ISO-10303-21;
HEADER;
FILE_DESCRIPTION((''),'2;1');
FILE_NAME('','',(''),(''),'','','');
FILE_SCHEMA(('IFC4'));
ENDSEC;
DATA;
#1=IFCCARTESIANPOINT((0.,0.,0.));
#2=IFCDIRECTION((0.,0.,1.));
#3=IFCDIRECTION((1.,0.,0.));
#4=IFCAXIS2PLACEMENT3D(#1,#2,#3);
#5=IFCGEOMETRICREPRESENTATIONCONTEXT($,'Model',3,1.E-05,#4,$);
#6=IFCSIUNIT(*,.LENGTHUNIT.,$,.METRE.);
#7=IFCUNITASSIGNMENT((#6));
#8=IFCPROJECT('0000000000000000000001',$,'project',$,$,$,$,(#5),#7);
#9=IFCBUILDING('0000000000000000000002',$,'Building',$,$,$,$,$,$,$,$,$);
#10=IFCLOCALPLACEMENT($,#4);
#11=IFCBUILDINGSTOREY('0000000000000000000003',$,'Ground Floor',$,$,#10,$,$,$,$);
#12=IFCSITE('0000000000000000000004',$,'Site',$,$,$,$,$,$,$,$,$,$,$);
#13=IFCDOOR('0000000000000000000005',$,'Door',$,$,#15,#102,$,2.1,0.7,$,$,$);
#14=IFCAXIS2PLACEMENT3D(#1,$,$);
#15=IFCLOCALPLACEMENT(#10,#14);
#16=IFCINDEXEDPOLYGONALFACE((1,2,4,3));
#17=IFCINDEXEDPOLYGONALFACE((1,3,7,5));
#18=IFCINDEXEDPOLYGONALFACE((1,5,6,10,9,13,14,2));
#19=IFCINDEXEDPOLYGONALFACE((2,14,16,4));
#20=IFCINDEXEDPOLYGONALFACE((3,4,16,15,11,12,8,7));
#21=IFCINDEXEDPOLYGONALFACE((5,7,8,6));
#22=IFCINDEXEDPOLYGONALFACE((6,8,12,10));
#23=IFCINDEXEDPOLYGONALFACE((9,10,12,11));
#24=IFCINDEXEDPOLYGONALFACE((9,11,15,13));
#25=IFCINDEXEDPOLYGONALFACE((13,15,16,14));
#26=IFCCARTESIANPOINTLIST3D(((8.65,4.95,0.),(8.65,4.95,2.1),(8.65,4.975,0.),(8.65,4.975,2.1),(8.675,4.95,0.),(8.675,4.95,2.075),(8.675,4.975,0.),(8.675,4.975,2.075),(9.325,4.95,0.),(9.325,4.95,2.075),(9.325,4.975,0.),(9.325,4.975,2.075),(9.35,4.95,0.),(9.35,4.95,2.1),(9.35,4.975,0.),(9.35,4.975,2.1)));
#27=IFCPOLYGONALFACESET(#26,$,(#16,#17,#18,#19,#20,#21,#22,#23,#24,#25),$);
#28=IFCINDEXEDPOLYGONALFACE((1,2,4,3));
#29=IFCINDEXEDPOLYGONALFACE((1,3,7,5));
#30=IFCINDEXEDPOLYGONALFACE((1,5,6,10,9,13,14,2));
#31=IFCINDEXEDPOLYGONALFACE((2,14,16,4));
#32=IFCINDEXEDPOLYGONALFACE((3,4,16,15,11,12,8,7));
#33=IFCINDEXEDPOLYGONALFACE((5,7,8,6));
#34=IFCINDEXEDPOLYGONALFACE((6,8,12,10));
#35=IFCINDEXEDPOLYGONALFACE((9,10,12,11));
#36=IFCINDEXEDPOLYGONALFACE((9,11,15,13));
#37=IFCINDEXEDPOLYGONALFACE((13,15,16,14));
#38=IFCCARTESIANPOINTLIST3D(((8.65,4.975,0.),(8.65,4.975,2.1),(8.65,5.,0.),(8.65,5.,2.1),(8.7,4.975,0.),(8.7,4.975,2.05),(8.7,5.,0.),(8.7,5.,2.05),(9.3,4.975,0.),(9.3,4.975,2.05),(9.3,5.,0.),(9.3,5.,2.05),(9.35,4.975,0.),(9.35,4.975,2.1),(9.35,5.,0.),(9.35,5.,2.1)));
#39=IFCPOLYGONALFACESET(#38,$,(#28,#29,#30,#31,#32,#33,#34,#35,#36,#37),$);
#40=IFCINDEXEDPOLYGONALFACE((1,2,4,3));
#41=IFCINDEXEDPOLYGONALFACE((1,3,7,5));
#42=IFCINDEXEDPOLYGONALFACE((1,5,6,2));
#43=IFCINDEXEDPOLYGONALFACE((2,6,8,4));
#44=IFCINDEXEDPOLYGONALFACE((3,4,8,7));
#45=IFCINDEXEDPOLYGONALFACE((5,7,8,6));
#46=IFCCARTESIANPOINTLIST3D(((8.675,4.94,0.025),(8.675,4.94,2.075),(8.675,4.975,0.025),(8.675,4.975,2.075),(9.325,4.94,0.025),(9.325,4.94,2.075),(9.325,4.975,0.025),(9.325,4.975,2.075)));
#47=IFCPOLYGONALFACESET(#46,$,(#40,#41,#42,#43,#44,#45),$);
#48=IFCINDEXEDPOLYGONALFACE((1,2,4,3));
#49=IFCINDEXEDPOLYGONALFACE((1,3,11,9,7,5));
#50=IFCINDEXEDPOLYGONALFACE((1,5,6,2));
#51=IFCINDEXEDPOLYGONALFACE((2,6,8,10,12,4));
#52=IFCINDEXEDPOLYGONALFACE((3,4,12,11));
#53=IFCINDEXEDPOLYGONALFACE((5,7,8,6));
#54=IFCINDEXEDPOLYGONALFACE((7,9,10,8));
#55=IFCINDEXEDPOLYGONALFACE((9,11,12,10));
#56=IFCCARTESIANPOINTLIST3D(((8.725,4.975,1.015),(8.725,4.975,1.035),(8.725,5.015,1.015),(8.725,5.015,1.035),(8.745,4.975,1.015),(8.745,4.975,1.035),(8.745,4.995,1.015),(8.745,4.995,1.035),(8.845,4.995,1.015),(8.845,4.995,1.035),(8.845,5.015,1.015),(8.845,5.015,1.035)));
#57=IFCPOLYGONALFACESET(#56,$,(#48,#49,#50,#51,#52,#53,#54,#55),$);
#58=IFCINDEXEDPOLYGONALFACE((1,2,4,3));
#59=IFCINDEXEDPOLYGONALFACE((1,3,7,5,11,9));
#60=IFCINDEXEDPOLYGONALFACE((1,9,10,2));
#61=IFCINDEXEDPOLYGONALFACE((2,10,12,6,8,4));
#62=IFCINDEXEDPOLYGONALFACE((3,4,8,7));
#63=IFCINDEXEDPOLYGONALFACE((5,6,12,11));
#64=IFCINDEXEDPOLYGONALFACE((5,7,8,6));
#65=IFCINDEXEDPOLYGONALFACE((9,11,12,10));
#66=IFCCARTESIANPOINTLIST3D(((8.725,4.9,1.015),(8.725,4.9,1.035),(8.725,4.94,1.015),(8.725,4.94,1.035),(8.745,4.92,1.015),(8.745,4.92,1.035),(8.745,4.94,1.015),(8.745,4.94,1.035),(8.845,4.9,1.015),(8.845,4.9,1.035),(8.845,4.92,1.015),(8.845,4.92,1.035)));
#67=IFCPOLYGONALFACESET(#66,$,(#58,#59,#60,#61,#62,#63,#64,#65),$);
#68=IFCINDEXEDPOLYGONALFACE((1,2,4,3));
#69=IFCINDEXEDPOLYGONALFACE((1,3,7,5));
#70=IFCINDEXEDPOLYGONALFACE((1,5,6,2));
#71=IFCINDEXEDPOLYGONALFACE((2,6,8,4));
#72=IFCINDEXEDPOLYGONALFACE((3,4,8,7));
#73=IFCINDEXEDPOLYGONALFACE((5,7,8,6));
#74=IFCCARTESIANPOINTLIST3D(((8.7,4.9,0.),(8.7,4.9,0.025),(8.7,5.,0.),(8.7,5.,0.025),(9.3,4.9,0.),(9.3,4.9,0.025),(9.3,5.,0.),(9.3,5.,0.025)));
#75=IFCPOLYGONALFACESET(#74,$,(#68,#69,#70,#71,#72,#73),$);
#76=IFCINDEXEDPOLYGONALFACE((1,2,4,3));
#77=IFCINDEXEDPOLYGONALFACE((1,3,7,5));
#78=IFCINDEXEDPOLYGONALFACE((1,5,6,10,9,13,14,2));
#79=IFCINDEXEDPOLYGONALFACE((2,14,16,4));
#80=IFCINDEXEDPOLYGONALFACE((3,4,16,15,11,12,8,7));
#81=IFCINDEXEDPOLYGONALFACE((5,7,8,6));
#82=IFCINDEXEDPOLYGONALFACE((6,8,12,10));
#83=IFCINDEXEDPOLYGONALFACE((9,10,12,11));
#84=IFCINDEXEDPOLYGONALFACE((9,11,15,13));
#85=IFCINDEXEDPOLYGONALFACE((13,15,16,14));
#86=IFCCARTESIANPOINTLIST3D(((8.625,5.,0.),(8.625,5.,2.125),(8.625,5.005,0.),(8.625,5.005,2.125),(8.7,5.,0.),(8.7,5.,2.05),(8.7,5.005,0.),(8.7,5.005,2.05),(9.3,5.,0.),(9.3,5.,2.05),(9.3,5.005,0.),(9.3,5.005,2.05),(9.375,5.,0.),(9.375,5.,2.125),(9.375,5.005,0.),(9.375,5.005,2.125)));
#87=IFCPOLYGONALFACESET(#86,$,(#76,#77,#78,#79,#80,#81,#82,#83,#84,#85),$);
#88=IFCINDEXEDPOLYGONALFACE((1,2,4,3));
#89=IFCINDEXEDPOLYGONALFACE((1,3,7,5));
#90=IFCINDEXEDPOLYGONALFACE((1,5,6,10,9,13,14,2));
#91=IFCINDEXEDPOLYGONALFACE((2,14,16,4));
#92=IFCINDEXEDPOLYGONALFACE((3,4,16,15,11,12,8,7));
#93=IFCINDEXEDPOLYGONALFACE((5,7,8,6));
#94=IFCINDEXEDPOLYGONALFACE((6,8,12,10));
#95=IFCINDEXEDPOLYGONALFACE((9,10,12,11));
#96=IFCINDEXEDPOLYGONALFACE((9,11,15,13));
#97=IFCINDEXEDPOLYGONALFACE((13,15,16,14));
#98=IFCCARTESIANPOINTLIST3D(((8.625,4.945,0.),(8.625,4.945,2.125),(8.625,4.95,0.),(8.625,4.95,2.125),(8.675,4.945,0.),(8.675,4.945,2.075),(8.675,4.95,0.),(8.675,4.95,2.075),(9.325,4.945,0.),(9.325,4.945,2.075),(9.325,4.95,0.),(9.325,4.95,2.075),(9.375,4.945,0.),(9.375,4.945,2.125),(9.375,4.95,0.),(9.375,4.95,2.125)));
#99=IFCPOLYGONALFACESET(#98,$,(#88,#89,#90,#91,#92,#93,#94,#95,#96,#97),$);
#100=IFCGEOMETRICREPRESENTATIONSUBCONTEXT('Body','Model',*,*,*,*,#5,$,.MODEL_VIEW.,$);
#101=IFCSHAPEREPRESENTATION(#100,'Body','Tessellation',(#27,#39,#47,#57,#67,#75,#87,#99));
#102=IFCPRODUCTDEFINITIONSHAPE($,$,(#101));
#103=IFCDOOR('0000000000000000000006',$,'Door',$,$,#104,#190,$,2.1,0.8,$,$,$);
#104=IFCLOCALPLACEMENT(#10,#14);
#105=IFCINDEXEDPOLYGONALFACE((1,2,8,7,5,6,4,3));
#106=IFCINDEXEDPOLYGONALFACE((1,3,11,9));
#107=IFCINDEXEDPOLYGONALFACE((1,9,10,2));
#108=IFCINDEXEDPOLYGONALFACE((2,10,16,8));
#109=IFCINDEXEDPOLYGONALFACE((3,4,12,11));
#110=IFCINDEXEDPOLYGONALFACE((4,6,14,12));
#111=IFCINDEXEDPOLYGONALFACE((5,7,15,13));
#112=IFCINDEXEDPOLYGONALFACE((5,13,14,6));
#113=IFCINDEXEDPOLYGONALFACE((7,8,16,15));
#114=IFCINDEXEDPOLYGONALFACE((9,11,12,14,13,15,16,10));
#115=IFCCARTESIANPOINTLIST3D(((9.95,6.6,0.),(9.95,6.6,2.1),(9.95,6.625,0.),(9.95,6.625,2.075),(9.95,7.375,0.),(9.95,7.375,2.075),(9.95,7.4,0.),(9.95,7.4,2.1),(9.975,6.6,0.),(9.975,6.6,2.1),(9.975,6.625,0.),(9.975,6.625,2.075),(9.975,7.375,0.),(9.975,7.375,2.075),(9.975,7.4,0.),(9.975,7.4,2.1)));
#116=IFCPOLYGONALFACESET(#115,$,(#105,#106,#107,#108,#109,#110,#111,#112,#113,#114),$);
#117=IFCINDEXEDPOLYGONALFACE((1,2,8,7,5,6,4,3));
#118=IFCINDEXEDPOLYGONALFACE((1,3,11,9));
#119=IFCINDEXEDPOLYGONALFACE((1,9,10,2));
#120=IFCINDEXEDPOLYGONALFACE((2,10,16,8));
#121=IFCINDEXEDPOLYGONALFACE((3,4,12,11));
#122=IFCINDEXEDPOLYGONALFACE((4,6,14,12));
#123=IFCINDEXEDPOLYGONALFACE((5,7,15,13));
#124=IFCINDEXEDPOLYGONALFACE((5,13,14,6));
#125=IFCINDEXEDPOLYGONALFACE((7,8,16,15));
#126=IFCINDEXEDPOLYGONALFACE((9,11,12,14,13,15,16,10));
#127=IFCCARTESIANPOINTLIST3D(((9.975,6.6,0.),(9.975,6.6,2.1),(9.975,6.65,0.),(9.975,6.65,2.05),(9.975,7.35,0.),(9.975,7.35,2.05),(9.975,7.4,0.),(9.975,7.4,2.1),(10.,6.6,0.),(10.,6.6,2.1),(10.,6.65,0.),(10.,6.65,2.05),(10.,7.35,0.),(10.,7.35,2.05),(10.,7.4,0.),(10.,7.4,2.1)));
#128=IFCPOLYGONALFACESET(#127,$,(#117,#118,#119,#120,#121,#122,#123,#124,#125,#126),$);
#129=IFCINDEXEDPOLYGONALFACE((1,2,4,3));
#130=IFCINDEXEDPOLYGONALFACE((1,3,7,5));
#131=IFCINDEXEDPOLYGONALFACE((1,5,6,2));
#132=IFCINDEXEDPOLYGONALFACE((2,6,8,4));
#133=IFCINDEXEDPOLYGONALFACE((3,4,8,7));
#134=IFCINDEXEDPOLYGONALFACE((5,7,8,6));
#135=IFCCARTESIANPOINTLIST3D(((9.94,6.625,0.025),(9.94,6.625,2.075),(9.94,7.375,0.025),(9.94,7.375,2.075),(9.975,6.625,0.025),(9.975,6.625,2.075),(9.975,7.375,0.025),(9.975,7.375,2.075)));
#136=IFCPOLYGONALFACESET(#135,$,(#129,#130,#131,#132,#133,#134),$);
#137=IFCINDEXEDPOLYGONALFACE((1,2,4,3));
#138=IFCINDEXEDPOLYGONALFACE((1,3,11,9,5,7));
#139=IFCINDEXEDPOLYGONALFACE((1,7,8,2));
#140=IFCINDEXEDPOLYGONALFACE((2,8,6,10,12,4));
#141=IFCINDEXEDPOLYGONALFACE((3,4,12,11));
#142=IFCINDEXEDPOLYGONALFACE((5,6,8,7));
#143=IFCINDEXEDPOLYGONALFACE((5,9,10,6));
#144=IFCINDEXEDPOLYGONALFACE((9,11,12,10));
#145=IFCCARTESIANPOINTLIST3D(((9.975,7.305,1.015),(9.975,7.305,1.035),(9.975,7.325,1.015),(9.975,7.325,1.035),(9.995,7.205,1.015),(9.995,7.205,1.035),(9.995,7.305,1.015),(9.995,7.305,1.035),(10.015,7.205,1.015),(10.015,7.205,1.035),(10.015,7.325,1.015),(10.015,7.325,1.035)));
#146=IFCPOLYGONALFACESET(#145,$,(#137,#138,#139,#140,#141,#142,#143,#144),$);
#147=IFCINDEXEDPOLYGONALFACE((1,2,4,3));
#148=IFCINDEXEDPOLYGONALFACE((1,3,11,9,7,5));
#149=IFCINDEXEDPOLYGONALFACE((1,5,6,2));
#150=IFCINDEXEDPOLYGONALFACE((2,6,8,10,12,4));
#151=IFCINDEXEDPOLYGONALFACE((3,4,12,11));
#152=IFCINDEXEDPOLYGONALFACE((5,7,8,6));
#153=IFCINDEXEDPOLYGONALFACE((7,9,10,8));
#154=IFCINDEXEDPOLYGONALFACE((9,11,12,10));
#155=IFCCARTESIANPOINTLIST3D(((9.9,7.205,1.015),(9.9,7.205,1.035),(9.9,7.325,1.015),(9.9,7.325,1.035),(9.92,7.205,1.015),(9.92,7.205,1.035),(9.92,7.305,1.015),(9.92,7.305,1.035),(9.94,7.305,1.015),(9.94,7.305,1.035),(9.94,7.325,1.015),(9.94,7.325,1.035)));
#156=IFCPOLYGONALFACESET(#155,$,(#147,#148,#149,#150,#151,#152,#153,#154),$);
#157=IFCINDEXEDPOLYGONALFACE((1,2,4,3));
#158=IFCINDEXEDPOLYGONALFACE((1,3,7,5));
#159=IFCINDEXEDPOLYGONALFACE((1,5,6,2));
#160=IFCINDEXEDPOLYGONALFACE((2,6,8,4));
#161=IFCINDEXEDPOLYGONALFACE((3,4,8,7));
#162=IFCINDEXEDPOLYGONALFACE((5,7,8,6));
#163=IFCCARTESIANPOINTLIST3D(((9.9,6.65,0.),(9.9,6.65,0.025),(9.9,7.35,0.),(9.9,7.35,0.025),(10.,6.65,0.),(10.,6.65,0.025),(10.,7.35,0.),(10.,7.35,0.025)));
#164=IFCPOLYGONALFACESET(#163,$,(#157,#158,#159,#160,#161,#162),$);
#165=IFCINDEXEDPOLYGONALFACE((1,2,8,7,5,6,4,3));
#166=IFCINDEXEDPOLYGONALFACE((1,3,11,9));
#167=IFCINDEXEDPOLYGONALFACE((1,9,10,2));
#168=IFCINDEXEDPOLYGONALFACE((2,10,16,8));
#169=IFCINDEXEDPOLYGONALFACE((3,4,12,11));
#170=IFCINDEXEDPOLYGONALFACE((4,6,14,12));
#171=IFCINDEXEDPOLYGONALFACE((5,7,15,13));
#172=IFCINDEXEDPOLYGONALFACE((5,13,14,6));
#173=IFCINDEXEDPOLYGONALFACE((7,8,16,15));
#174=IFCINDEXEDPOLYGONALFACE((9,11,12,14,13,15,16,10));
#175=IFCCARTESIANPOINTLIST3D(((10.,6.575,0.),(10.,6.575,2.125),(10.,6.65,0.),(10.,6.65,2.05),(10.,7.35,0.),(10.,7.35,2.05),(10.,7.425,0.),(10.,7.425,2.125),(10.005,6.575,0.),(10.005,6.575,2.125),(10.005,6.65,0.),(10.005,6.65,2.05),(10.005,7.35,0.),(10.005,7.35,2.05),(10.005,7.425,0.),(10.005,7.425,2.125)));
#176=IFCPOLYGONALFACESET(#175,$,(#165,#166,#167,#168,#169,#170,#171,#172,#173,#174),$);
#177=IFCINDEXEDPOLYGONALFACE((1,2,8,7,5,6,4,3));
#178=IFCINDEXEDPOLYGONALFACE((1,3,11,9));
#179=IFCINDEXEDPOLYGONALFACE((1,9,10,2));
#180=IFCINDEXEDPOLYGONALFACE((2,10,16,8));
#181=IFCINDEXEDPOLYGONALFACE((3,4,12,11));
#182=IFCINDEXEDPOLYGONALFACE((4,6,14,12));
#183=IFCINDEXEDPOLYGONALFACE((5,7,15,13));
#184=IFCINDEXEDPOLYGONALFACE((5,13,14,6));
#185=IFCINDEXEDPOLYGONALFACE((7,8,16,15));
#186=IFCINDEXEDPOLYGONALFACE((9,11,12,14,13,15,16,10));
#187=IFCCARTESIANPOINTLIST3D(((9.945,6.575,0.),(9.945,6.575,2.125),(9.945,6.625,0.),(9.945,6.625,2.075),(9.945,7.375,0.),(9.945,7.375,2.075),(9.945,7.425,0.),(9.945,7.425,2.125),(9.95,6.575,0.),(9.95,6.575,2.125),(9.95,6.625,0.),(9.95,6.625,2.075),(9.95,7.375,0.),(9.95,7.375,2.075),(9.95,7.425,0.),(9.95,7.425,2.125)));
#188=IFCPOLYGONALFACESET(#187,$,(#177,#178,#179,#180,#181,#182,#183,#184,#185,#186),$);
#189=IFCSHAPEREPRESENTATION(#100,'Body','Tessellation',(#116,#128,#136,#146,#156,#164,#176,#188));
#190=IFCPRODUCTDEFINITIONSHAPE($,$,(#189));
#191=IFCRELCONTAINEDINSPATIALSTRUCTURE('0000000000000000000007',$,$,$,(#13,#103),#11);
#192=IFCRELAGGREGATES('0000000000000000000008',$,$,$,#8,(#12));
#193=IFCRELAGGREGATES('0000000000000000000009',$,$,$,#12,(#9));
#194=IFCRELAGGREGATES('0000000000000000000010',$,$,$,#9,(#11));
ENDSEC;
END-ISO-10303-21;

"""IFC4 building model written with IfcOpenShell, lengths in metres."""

from ifc_helpers import new_model, si_unit, frame, origin_with_axes, place, context, subcontext, project, spatial, line, indexed_curve, outline, extrude, element, save


model = new_model("IFC4")

# Units and contexts
model_context = context("Model", 3, precision=1e-05, world=origin_with_axes())
body_context = subcontext(model_context, "Body", "Model", "MODEL_VIEW")
ifc_project = project(units=[si_unit("LENGTHUNIT", "METRE")], contexts=[model_context])

# Site, building, storey
site = spatial("IfcSite", under=ifc_project, Name="Site")
building = spatial("IfcBuilding", under=site, Name="Building")
storey_placement = place(None, origin_with_axes())
storey = spatial("IfcBuildingStorey", under=building, at=storey_placement, Name="Ground Floor")

# Doors
door_1_placement = place(storey_placement, frame((9.35, 5.0, 0.0), z_axis=(0.0, 0.0, 1.0), x_axis=(-1.0, 0.0, 0.0)))
element("IfcDoor", 1, at=door_1_placement, inside=storey, Name="Door", OverallHeight=2.1, OverallWidth=0.7, context=body_context, shape_type="SweptSolid", body=[
    extrude(outline(indexed_curve([(0.0, 0.0), (0.0, 2.1), (0.7, 2.1), (0.7, 0.0), (0.675, 0.0), (0.675, 2.075), (0.025, 2.075), (0.025, 0.0)], segments=[line(1, 2, 3, 4, 5, 6, 7, 8, 1)])), frame((0.0, 0.025, 0.0), z_axis=(0.0, -1.0, 0.0), x_axis=(1.0, 0.0, 0.0)), (0.0, 0.0, -1.0), 0.025),
    extrude(outline(indexed_curve([(0.0, 0.0), (0.0, 2.1), (0.7, 2.1), (0.7, 0.0), (0.65, 0.0), (0.65, 2.05), (0.05, 2.05), (0.05, 0.0)], segments=[line(1, 2, 3, 4, 5, 6, 7, 8, 1)])), frame((0.0, 0.0, 0.0), z_axis=(0.0, -1.0, 0.0), x_axis=(1.0, 0.0, 0.0)), (0.0, 0.0, -1.0), 0.025),
    extrude(outline(indexed_curve([(0.0, 0.0), (0.65, 0.0), (0.65, 0.035), (0.0, 0.035)], segments=[line(1, 2, 3, 4, 1)])), frame((0.025, 0.025, 0.025), z_axis=(0.0, 0.0, 1.0), x_axis=(1.0, 0.0, 0.0)), (0.0, 0.0, 1.0), 2.05),
    extrude(outline(indexed_curve([(0.0, 0.0), (0.0, -0.04), (-0.12, -0.04), (-0.12, -0.02), (-0.02, -0.02), (-0.02, 0.0)], segments=[line(1, 2, 3, 4, 5, 6, 1)])), frame((0.625, 0.025, 1.015), z_axis=(0.0, 0.0, 1.0), x_axis=(1.0, 0.0, 0.0)), (0.0, 0.0, 1.0), 0.02),
    extrude(outline(indexed_curve([(0.0, 0.0), (0.0, 0.04), (-0.12, 0.04), (-0.12, 0.02), (-0.02, 0.02), (-0.02, 0.0)], segments=[line(1, 2, 3, 4, 5, 6, 1)])), frame((0.625, 0.06, 1.015), z_axis=(0.0, 0.0, 1.0), x_axis=(1.0, 0.0, 0.0)), (0.0, 0.0, 1.0), 0.02),
    extrude(outline(indexed_curve([(0.0, 0.0), (0.6, 0.0), (0.6, 0.1), (0.0, 0.1)], segments=[line(1, 2, 3, 4, 1)])), frame((0.05, 0.0, 0.0), z_axis=(0.0, 0.0, 1.0), x_axis=(1.0, 0.0, 0.0)), (0.0, 0.0, 1.0), 0.025),
    extrude(outline(indexed_curve([(0.0, 0.0), (0.0, 2.125), (0.75, 2.125), (0.75, 0.0), (0.675, 0.0), (0.675, 2.05), (0.075, 2.05), (0.075, 0.0)], segments=[line(1, 2, 3, 4, 5, 6, 7, 8, 1)])), frame((-0.025, -0.005, 0.0), z_axis=(0.0, -1.0, 0.0), x_axis=(1.0, 0.0, 0.0)), (0.0, 0.0, -1.0), 0.005),
    extrude(outline(indexed_curve([(0.0, 0.0), (0.0, 2.125), (0.75, 2.125), (0.75, 0.0), (0.7, 0.0), (0.7, 2.075), (0.05, 2.075), (0.05, 0.0)], segments=[line(1, 2, 3, 4, 5, 6, 7, 8, 1)])), frame((-0.025, 0.05, 0.0), z_axis=(0.0, -1.0, 0.0), x_axis=(1.0, 0.0, 0.0)), (0.0, 0.0, -1.0), 0.005),
])
door_2_placement = place(storey_placement, frame((10.0, 6.6, 0.0), z_axis=(0.0, 0.0, 1.0), x_axis=(0.0, 1.0, 0.0)))
element("IfcDoor", 2, at=door_2_placement, inside=storey, Name="Door", OverallHeight=2.1, OverallWidth=0.8, context=body_context, shape_type="SweptSolid", body=[
    extrude(outline(indexed_curve([(0.0, 0.0), (0.0, 2.1), (0.8, 2.1), (0.8, 0.0), (0.775, 0.0), (0.775, 2.075), (0.025, 2.075), (0.025, 0.0)], segments=[line(1, 2, 3, 4, 5, 6, 7, 8, 1)])), frame((0.0, 0.025, 0.0), z_axis=(0.0, -1.0, 0.0), x_axis=(1.0, 0.0, 0.0)), (0.0, 0.0, -1.0), 0.025),
    extrude(outline(indexed_curve([(0.0, 0.0), (0.0, 2.1), (0.8, 2.1), (0.8, 0.0), (0.75, 0.0), (0.75, 2.05), (0.05, 2.05), (0.05, 0.0)], segments=[line(1, 2, 3, 4, 5, 6, 7, 8, 1)])), frame((0.0, 0.0, 0.0), z_axis=(0.0, -1.0, 0.0), x_axis=(1.0, 0.0, 0.0)), (0.0, 0.0, -1.0), 0.025),
    extrude(outline(indexed_curve([(0.0, 0.0), (0.75, 0.0), (0.75, 0.035), (0.0, 0.035)], segments=[line(1, 2, 3, 4, 1)])), frame((0.025, 0.025, 0.025), z_axis=(0.0, 0.0, 1.0), x_axis=(1.0, 0.0, 0.0)), (0.0, 0.0, 1.0), 2.05),
    extrude(outline(indexed_curve([(0.0, 0.0), (0.0, -0.04), (-0.12, -0.04), (-0.12, -0.02), (-0.02, -0.02), (-0.02, 0.0)], segments=[line(1, 2, 3, 4, 5, 6, 1)])), frame((0.725, 0.025, 1.015), z_axis=(0.0, 0.0, 1.0), x_axis=(1.0, 0.0, 0.0)), (0.0, 0.0, 1.0), 0.02),
    extrude(outline(indexed_curve([(0.0, 0.0), (0.0, 0.04), (-0.12, 0.04), (-0.12, 0.02), (-0.02, 0.02), (-0.02, 0.0)], segments=[line(1, 2, 3, 4, 5, 6, 1)])), frame((0.725, 0.06, 1.015), z_axis=(0.0, 0.0, 1.0), x_axis=(1.0, 0.0, 0.0)), (0.0, 0.0, 1.0), 0.02),
    extrude(outline(indexed_curve([(0.0, 0.0), (0.7, 0.0), (0.7, 0.1), (0.0, 0.1)], segments=[line(1, 2, 3, 4, 1)])), frame((0.05, 0.0, 0.0), z_axis=(0.0, 0.0, 1.0), x_axis=(1.0, 0.0, 0.0)), (0.0, 0.0, 1.0), 0.025),
    extrude(outline(indexed_curve([(0.0, 0.0), (0.0, 2.125), (0.85, 2.125), (0.85, 0.0), (0.775, 0.0), (0.775, 2.05), (0.075, 2.05), (0.075, 0.0)], segments=[line(1, 2, 3, 4, 5, 6, 7, 8, 1)])), frame((-0.025, -0.005, 0.0), z_axis=(0.0, -1.0, 0.0), x_axis=(1.0, 0.0, 0.0)), (0.0, 0.0, -1.0), 0.005),
    extrude(outline(indexed_curve([(0.0, 0.0), (0.0, 2.125), (0.85, 2.125), (0.85, 0.0), (0.8, 0.0), (0.8, 2.075), (0.05, 2.075), (0.05, 0.0)], segments=[line(1, 2, 3, 4, 5, 6, 7, 8, 1)])), frame((-0.025, 0.05, 0.0), z_axis=(0.0, -1.0, 0.0), x_axis=(1.0, 0.0, 0.0)), (0.0, 0.0, -1.0), 0.005),
])

save(model, "model.ifc")
